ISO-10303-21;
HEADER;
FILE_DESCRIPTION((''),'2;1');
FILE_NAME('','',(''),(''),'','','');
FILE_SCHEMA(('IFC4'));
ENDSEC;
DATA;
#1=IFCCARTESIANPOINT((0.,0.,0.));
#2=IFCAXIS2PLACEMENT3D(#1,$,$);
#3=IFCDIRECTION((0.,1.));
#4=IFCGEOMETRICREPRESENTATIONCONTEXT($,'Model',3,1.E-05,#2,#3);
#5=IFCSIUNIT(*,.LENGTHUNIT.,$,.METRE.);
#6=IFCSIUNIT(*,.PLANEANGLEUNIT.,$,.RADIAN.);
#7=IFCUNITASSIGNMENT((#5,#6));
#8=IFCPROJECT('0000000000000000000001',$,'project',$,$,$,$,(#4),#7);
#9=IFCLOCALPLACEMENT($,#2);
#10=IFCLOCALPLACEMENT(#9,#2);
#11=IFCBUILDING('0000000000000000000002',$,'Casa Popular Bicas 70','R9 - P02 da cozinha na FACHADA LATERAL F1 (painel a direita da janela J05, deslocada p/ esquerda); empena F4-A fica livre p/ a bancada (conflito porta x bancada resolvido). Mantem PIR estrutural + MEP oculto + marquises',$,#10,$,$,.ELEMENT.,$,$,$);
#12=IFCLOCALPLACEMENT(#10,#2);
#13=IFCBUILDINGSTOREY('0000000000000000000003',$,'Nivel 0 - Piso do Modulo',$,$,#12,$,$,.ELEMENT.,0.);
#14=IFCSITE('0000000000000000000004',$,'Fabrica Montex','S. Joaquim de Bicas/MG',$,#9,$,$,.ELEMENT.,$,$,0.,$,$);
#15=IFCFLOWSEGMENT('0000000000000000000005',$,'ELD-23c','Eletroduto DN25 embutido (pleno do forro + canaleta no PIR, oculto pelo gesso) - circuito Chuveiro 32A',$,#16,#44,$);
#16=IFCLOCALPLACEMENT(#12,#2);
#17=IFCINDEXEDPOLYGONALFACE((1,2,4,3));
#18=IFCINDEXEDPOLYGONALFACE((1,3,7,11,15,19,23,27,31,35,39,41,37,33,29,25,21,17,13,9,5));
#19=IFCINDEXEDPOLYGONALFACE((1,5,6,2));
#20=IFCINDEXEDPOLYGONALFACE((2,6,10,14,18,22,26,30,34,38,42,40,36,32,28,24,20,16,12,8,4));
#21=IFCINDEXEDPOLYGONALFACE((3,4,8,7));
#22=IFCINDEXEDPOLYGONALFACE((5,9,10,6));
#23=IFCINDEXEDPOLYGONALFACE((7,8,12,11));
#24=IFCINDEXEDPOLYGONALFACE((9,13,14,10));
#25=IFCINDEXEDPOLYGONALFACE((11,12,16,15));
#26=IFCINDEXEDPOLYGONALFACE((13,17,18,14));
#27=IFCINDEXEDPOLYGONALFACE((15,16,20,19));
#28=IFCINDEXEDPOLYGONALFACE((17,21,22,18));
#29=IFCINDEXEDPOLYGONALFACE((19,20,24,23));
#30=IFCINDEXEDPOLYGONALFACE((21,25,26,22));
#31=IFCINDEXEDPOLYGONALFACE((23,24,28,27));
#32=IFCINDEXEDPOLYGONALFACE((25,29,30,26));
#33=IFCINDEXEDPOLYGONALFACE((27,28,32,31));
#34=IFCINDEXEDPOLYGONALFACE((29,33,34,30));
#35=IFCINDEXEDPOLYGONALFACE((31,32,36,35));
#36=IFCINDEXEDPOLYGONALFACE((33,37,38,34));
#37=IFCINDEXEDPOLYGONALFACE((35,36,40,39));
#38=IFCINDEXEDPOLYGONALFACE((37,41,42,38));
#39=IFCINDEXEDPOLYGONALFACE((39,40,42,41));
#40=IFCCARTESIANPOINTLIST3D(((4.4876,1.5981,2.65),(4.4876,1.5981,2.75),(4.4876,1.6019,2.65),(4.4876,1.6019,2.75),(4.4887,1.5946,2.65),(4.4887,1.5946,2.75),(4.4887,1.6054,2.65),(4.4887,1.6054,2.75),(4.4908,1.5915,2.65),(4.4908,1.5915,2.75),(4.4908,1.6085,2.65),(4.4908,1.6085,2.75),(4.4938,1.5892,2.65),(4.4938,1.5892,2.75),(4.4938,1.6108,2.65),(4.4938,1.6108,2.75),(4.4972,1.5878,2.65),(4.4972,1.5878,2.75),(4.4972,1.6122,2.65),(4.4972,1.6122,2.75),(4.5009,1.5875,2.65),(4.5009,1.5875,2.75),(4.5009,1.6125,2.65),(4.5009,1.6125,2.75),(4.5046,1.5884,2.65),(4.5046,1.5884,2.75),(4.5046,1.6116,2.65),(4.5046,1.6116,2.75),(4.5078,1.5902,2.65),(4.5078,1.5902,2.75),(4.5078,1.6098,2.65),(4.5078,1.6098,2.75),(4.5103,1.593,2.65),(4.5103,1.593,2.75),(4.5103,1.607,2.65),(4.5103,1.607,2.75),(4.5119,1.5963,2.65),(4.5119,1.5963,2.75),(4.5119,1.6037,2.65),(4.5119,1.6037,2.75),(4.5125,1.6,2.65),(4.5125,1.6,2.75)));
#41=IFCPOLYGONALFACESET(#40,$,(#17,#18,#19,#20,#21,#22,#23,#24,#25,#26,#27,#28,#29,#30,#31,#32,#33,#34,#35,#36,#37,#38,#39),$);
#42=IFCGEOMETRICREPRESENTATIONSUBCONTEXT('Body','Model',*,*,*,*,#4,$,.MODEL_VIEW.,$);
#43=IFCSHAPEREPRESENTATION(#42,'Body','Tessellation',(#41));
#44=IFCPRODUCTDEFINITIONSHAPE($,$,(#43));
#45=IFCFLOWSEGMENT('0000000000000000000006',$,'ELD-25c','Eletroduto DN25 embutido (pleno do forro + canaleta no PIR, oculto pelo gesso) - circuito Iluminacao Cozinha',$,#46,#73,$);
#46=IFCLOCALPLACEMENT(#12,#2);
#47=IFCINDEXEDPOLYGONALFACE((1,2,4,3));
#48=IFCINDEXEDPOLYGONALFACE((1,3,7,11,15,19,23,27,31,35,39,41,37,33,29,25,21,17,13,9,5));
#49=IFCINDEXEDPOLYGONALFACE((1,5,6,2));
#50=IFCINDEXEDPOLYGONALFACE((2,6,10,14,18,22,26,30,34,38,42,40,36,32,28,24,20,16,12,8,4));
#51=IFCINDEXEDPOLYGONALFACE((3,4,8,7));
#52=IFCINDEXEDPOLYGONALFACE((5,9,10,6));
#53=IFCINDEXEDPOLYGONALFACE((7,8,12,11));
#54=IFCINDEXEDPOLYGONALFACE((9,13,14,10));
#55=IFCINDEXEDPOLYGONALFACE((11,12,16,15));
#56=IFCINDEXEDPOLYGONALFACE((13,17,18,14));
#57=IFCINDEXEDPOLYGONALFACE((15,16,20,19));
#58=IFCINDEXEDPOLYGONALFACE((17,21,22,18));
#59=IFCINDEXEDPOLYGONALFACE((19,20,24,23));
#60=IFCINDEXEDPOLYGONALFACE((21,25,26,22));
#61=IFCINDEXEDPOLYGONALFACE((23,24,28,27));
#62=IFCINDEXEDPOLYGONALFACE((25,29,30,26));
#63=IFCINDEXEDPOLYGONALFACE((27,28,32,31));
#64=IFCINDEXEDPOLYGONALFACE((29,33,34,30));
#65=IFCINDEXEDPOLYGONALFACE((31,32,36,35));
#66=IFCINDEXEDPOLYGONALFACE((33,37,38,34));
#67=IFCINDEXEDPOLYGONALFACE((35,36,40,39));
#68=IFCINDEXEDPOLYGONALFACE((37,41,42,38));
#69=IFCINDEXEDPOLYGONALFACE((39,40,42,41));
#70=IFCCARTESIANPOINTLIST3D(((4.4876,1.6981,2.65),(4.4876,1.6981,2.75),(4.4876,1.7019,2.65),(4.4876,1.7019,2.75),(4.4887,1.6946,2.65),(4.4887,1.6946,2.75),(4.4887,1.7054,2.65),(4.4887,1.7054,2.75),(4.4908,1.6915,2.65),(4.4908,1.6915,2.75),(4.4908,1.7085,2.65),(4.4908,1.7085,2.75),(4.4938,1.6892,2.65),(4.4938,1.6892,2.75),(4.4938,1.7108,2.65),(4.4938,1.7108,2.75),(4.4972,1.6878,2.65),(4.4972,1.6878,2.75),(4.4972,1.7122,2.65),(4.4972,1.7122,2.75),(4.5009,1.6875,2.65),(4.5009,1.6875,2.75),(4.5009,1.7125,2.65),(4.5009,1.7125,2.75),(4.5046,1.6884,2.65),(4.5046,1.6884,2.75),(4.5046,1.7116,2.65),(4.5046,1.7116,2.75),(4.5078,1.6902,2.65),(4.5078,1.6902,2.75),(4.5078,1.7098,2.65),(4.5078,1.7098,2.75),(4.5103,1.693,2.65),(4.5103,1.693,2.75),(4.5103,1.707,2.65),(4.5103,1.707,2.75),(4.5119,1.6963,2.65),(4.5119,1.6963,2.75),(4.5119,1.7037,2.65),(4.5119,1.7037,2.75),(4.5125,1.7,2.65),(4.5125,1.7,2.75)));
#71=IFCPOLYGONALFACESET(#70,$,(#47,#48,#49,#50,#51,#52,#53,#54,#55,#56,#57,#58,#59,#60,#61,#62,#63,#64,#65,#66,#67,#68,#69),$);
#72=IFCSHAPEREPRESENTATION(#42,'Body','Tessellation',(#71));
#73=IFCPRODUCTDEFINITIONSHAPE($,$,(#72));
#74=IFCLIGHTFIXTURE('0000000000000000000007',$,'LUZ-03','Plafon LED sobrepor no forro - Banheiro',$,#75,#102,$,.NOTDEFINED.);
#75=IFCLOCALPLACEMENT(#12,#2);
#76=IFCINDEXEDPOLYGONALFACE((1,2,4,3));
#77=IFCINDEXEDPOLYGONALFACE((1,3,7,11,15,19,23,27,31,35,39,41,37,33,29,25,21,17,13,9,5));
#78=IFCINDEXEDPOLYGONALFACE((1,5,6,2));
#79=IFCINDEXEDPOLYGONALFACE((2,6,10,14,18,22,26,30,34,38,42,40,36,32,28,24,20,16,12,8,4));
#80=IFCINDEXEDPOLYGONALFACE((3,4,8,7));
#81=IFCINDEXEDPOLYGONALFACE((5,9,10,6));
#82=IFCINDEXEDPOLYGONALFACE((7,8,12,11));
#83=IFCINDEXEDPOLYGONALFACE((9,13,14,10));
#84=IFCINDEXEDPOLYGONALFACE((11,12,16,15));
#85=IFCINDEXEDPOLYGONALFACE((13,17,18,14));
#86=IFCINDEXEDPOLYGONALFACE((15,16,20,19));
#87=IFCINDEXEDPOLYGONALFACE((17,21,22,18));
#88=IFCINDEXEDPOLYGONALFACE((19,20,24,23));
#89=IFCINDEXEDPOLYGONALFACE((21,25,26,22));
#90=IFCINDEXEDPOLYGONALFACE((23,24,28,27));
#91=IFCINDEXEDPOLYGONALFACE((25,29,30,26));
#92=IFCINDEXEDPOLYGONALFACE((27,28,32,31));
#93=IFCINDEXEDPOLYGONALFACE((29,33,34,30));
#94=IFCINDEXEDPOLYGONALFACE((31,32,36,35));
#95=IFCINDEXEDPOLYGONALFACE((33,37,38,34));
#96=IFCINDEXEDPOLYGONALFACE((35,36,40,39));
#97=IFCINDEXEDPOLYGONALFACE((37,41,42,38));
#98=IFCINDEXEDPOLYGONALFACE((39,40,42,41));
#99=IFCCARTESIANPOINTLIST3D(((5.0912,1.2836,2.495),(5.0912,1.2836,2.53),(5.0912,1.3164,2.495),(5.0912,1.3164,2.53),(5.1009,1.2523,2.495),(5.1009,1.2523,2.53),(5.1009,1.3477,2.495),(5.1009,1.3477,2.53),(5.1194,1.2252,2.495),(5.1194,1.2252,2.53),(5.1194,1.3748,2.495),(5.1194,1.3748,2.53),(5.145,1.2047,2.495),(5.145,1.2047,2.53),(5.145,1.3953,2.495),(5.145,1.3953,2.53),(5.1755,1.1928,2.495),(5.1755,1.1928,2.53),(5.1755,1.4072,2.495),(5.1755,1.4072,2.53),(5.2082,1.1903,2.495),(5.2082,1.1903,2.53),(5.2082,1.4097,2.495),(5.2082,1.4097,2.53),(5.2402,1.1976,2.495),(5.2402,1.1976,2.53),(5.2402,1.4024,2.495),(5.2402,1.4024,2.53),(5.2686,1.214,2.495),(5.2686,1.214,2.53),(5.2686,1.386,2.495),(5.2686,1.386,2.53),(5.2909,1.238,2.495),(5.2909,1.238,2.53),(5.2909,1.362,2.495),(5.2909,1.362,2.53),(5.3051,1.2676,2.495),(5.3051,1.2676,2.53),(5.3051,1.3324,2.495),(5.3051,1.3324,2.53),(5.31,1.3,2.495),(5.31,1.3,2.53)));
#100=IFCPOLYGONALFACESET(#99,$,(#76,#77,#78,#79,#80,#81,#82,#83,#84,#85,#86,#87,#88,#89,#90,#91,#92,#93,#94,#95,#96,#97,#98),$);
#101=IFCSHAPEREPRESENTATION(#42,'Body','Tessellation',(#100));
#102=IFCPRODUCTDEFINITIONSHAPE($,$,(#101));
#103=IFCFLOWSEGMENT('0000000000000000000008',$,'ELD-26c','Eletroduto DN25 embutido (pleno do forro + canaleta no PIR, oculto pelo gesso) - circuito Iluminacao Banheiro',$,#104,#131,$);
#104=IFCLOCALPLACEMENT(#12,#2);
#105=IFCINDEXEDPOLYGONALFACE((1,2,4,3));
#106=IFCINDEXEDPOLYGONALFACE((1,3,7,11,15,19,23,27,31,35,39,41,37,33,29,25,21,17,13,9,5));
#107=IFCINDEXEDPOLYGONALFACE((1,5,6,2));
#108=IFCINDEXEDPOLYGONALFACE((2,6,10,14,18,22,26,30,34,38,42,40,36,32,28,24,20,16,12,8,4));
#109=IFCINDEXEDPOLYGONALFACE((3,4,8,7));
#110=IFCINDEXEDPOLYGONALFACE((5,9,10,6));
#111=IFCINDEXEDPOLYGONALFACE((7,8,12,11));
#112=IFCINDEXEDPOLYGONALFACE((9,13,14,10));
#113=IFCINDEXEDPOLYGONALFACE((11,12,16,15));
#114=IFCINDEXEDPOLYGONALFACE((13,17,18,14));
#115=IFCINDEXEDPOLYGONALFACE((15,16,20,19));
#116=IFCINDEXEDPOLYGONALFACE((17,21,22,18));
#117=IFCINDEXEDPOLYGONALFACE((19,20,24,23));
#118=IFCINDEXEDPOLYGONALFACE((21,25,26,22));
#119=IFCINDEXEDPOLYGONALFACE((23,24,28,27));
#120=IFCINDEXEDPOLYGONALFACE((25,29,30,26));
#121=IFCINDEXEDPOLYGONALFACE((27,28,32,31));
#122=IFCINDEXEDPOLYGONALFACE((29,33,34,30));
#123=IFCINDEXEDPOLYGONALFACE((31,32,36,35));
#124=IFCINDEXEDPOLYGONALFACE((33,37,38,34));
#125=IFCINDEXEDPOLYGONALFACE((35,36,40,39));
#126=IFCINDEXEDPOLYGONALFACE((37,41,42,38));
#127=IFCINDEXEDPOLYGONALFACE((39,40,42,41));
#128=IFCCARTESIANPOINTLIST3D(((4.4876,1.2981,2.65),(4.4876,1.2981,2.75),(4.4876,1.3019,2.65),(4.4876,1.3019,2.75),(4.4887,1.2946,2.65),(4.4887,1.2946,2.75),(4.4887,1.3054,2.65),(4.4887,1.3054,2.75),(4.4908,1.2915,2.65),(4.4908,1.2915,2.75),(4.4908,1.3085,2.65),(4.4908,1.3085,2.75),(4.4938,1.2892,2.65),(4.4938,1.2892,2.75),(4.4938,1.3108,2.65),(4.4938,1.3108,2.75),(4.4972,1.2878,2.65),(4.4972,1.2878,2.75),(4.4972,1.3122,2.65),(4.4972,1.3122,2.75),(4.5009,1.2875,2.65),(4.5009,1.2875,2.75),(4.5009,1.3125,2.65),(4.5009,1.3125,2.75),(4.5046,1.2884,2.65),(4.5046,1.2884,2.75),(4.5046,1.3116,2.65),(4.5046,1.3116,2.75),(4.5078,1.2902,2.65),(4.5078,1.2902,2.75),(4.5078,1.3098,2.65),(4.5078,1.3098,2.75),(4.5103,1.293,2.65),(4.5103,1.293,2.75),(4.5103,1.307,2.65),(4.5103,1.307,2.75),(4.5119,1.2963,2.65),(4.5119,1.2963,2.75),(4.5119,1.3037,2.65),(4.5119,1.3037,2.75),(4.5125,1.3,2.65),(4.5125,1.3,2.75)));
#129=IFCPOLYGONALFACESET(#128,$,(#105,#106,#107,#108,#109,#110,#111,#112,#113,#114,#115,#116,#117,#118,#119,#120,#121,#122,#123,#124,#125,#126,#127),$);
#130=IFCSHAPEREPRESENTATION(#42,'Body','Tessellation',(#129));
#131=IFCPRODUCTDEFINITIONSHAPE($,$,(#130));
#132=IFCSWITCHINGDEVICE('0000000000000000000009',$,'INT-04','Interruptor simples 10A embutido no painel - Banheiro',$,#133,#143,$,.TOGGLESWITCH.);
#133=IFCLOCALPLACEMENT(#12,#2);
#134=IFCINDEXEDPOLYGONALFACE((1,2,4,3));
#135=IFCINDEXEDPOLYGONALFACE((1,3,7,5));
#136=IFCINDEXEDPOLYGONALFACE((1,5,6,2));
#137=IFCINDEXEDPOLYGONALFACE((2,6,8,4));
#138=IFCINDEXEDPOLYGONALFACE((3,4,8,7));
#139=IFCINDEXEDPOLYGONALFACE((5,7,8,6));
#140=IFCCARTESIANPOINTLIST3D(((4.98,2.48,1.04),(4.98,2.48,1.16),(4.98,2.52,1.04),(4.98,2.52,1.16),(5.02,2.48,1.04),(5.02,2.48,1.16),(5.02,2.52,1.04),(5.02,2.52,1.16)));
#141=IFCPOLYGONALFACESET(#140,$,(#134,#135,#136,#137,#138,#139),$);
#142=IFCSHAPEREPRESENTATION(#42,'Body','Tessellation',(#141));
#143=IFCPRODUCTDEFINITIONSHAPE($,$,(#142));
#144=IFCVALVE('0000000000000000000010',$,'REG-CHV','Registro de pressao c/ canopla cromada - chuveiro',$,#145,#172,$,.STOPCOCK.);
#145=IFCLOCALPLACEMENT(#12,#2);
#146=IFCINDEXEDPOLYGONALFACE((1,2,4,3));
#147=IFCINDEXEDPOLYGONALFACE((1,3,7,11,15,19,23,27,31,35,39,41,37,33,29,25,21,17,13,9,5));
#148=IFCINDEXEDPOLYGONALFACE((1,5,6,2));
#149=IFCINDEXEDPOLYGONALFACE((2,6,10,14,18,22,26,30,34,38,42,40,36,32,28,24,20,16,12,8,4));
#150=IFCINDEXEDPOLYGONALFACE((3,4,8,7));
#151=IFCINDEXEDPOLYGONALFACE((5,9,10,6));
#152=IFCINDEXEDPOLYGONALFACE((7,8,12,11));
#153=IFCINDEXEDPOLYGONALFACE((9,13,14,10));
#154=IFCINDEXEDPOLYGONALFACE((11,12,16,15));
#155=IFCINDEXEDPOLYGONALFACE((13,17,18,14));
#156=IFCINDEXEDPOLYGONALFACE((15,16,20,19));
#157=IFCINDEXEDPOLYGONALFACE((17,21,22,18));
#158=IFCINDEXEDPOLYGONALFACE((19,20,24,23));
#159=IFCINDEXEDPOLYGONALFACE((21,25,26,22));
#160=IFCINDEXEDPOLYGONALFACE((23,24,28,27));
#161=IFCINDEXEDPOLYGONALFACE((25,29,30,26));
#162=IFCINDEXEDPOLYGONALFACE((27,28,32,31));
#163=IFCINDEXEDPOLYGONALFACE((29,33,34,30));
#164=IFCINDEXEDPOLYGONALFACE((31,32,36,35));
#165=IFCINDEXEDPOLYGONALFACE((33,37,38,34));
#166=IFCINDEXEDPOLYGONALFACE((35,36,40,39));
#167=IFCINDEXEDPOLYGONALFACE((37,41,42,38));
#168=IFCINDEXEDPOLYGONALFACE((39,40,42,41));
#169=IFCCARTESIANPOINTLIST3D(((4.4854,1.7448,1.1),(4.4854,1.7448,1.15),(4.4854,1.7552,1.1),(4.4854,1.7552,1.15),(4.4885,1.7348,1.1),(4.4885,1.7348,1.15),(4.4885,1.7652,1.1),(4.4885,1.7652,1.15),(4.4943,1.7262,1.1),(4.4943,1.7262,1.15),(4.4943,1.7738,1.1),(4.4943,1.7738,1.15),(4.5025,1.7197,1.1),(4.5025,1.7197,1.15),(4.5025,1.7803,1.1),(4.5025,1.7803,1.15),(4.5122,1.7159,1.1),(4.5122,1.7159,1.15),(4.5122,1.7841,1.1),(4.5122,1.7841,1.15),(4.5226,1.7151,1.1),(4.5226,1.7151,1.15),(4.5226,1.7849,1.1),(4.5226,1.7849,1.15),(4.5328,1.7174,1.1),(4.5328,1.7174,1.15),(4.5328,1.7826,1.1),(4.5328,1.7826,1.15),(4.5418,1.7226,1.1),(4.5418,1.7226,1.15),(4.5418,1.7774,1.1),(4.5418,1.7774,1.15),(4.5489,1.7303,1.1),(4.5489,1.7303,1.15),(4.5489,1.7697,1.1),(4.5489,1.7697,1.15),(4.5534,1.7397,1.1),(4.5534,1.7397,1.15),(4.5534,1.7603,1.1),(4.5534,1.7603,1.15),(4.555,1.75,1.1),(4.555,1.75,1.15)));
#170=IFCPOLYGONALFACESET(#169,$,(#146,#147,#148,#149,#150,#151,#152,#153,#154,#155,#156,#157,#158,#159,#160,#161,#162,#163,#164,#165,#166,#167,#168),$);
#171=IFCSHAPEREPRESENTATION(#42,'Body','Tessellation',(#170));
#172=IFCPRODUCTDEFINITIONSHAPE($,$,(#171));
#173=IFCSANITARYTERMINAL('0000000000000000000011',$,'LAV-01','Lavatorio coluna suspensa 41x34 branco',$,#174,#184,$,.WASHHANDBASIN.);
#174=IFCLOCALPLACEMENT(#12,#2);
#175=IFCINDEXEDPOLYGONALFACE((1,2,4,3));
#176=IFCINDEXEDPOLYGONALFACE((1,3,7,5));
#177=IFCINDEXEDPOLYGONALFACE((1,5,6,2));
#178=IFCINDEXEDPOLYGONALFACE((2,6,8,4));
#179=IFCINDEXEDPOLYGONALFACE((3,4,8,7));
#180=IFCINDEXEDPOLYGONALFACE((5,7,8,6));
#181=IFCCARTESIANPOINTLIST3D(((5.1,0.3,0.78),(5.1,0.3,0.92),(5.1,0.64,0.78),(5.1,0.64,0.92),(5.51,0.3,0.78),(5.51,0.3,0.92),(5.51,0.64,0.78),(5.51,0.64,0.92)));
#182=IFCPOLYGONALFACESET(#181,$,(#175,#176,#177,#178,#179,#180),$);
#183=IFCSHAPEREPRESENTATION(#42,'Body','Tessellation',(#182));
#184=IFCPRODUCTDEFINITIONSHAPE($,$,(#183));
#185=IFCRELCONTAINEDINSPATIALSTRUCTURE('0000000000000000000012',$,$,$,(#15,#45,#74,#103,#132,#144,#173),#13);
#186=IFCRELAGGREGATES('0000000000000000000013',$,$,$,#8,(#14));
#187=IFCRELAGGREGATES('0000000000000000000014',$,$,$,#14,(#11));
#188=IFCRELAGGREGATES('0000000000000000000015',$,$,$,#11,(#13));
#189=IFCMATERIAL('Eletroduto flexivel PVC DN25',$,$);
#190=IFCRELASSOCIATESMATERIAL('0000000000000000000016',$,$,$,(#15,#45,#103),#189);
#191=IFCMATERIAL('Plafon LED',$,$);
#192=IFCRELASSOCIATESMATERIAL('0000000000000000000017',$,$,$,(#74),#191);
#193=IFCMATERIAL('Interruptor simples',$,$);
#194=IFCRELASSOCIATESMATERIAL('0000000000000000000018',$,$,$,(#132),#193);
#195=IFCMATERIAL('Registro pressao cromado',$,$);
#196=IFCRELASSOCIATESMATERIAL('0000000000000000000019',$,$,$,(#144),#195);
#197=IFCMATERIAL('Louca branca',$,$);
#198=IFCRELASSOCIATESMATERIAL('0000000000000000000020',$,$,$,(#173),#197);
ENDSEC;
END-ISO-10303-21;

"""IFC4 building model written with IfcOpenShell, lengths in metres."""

from ifc_helpers import new_model, si_unit, direction, frame, frame_2d, origin, origin_2d, place, context, subcontext, project, spatial, rectangle, circle, extrude, material, element, save


model = new_model("IFC4")

# Units and contexts
model_context = context("Model", 3, precision=1e-05, world=origin(), true_north=direction((0.0, 1.0)))
body_context = subcontext(model_context, "Body", "Model", "MODEL_VIEW")
ifc_project = project(units=[si_unit("LENGTHUNIT", "METRE"), si_unit("PLANEANGLEUNIT", "RADIAN")], contexts=[model_context])

# Site, building, storey
site_placement = place(None, origin())
site = spatial("IfcSite", under=ifc_project, at=site_placement, Name="Fabrica Montex", Description="S. Joaquim de Bicas/MG", CompositionType="ELEMENT", RefElevation=0.0)
building_placement = place(site_placement, origin())
building = spatial("IfcBuilding", under=site, at=building_placement, Name="Casa Popular Bicas 70", Description="R9 - P02 da cozinha na FACHADA LATERAL F1 (painel a direita da janela J05, deslocada p/ esquerda); empena F4-A fica livre p/ a bancada (conflito porta x bancada resolvido). Mantem PIR estrutural + MEP oculto + marquises", CompositionType="ELEMENT")
storey_placement = place(building_placement, origin())
storey = spatial("IfcBuildingStorey", under=building, at=storey_placement, Name="Nivel 0 - Piso do Modulo", CompositionType="ELEMENT", Elevation=0.0)

# Shared definitions
ifc_material_1 = material(Name="Eletroduto flexivel PVC DN25")

# Flow segments
for number, where, z_axis, x_axis, name, description in (
    (1, (4.5, 1.6, 2.75), (0.0, 0.0, -1.0), (1.0, 0.0, 0.0), "ELD-23c", "Eletroduto DN25 embutido (pleno do forro + canaleta no PIR, oculto pelo gesso) - circuito Chuveiro 32A"),
    (2, (4.5, 1.7, 2.75), (0.0, 0.0, -1.0), (1.0, 0.0, 0.0), "ELD-25c", "Eletroduto DN25 embutido (pleno do forro + canaleta no PIR, oculto pelo gesso) - circuito Iluminacao Cozinha"),
):
    element("IfcFlowSegment", number, at=place(storey_placement, frame(where, z_axis=z_axis, x_axis=x_axis)), inside=storey, material=ifc_material_1, Name=name, Description=description, context=body_context, shape_type="SweptSolid", body=[
        extrude(circle(Radius=0.0125, at=origin_2d()), origin(), (0.0, 0.0, 1.0), 0.1),
    ])

# Light fixture
ifc_material_2 = material(Name="Plafon LED")
light_fixture_placement = place(storey_placement, frame((5.2, 1.3, 2.495)))
element("IfcLightFixture", 3, at=light_fixture_placement, inside=storey, material=ifc_material_2, Name="LUZ-03", Description="Plafon LED sobrepor no forro - Banheiro", PredefinedType="NOTDEFINED", context=body_context, shape_type="SweptSolid", body=[
    extrude(circle(Radius=0.11, at=origin_2d()), origin(), (0.0, 0.0, 1.0), 0.035),
])

# Flow segment
flow_segment_1_placement = place(storey_placement, frame((4.5, 1.3, 2.75), z_axis=(0.0, 0.0, -1.0), x_axis=(1.0, 0.0, 0.0)))
element("IfcFlowSegment", 4, at=flow_segment_1_placement, inside=storey, material=ifc_material_1, Name="ELD-26c", Description="Eletroduto DN25 embutido (pleno do forro + canaleta no PIR, oculto pelo gesso) - circuito Iluminacao Banheiro", context=body_context, shape_type="SweptSolid", body=[
    extrude(circle(Radius=0.0125, at=origin_2d()), origin(), (0.0, 0.0, 1.0), 0.1),
])

# Switching device
ifc_material_3 = material(Name="Interruptor simples")
switching_device_placement = place(storey_placement, frame((4.98, 2.48, 1.04)))
element("IfcSwitchingDevice", 5, at=switching_device_placement, inside=storey, material=ifc_material_3, Name="INT-04", Description="Interruptor simples 10A embutido no painel - Banheiro", PredefinedType="TOGGLESWITCH", context=body_context, shape_type="SweptSolid", body=[
    extrude(rectangle(XDim=0.04, YDim=0.04, at=frame_2d((0.02, 0.02))), origin(), (0.0, 0.0, 1.0), 0.12),
])

# Valve
ifc_material_4 = material(Name="Registro pressao cromado")
valve_placement = place(storey_placement, frame((4.52, 1.75, 1.1)))
element("IfcValve", 6, at=valve_placement, inside=storey, material=ifc_material_4, Name="REG-CHV", Description="Registro de pressao c/ canopla cromada - chuveiro", PredefinedType="STOPCOCK", context=body_context, shape_type="SweptSolid", body=[
    extrude(circle(Radius=0.035, at=origin_2d()), origin(), (0.0, 0.0, 1.0), 0.05),
])

# Sanitary terminal
ifc_material_5 = material(Name="Louca branca")
sanitary_terminal_1_placement = place(storey_placement, frame((5.1, 0.3, 0.78)))
element("IfcSanitaryTerminal", 7, at=sanitary_terminal_1_placement, inside=storey, material=ifc_material_5, Name="LAV-01", Description="Lavatorio coluna suspensa 41x34 branco", PredefinedType="WASHHANDBASIN", context=body_context, shape_type="SweptSolid", body=[
    extrude(rectangle(XDim=0.41, YDim=0.34, at=frame_2d((0.205, 0.17))), origin(), (0.0, 0.0, 1.0), 0.14),
])

save(model, "model.ifc")
